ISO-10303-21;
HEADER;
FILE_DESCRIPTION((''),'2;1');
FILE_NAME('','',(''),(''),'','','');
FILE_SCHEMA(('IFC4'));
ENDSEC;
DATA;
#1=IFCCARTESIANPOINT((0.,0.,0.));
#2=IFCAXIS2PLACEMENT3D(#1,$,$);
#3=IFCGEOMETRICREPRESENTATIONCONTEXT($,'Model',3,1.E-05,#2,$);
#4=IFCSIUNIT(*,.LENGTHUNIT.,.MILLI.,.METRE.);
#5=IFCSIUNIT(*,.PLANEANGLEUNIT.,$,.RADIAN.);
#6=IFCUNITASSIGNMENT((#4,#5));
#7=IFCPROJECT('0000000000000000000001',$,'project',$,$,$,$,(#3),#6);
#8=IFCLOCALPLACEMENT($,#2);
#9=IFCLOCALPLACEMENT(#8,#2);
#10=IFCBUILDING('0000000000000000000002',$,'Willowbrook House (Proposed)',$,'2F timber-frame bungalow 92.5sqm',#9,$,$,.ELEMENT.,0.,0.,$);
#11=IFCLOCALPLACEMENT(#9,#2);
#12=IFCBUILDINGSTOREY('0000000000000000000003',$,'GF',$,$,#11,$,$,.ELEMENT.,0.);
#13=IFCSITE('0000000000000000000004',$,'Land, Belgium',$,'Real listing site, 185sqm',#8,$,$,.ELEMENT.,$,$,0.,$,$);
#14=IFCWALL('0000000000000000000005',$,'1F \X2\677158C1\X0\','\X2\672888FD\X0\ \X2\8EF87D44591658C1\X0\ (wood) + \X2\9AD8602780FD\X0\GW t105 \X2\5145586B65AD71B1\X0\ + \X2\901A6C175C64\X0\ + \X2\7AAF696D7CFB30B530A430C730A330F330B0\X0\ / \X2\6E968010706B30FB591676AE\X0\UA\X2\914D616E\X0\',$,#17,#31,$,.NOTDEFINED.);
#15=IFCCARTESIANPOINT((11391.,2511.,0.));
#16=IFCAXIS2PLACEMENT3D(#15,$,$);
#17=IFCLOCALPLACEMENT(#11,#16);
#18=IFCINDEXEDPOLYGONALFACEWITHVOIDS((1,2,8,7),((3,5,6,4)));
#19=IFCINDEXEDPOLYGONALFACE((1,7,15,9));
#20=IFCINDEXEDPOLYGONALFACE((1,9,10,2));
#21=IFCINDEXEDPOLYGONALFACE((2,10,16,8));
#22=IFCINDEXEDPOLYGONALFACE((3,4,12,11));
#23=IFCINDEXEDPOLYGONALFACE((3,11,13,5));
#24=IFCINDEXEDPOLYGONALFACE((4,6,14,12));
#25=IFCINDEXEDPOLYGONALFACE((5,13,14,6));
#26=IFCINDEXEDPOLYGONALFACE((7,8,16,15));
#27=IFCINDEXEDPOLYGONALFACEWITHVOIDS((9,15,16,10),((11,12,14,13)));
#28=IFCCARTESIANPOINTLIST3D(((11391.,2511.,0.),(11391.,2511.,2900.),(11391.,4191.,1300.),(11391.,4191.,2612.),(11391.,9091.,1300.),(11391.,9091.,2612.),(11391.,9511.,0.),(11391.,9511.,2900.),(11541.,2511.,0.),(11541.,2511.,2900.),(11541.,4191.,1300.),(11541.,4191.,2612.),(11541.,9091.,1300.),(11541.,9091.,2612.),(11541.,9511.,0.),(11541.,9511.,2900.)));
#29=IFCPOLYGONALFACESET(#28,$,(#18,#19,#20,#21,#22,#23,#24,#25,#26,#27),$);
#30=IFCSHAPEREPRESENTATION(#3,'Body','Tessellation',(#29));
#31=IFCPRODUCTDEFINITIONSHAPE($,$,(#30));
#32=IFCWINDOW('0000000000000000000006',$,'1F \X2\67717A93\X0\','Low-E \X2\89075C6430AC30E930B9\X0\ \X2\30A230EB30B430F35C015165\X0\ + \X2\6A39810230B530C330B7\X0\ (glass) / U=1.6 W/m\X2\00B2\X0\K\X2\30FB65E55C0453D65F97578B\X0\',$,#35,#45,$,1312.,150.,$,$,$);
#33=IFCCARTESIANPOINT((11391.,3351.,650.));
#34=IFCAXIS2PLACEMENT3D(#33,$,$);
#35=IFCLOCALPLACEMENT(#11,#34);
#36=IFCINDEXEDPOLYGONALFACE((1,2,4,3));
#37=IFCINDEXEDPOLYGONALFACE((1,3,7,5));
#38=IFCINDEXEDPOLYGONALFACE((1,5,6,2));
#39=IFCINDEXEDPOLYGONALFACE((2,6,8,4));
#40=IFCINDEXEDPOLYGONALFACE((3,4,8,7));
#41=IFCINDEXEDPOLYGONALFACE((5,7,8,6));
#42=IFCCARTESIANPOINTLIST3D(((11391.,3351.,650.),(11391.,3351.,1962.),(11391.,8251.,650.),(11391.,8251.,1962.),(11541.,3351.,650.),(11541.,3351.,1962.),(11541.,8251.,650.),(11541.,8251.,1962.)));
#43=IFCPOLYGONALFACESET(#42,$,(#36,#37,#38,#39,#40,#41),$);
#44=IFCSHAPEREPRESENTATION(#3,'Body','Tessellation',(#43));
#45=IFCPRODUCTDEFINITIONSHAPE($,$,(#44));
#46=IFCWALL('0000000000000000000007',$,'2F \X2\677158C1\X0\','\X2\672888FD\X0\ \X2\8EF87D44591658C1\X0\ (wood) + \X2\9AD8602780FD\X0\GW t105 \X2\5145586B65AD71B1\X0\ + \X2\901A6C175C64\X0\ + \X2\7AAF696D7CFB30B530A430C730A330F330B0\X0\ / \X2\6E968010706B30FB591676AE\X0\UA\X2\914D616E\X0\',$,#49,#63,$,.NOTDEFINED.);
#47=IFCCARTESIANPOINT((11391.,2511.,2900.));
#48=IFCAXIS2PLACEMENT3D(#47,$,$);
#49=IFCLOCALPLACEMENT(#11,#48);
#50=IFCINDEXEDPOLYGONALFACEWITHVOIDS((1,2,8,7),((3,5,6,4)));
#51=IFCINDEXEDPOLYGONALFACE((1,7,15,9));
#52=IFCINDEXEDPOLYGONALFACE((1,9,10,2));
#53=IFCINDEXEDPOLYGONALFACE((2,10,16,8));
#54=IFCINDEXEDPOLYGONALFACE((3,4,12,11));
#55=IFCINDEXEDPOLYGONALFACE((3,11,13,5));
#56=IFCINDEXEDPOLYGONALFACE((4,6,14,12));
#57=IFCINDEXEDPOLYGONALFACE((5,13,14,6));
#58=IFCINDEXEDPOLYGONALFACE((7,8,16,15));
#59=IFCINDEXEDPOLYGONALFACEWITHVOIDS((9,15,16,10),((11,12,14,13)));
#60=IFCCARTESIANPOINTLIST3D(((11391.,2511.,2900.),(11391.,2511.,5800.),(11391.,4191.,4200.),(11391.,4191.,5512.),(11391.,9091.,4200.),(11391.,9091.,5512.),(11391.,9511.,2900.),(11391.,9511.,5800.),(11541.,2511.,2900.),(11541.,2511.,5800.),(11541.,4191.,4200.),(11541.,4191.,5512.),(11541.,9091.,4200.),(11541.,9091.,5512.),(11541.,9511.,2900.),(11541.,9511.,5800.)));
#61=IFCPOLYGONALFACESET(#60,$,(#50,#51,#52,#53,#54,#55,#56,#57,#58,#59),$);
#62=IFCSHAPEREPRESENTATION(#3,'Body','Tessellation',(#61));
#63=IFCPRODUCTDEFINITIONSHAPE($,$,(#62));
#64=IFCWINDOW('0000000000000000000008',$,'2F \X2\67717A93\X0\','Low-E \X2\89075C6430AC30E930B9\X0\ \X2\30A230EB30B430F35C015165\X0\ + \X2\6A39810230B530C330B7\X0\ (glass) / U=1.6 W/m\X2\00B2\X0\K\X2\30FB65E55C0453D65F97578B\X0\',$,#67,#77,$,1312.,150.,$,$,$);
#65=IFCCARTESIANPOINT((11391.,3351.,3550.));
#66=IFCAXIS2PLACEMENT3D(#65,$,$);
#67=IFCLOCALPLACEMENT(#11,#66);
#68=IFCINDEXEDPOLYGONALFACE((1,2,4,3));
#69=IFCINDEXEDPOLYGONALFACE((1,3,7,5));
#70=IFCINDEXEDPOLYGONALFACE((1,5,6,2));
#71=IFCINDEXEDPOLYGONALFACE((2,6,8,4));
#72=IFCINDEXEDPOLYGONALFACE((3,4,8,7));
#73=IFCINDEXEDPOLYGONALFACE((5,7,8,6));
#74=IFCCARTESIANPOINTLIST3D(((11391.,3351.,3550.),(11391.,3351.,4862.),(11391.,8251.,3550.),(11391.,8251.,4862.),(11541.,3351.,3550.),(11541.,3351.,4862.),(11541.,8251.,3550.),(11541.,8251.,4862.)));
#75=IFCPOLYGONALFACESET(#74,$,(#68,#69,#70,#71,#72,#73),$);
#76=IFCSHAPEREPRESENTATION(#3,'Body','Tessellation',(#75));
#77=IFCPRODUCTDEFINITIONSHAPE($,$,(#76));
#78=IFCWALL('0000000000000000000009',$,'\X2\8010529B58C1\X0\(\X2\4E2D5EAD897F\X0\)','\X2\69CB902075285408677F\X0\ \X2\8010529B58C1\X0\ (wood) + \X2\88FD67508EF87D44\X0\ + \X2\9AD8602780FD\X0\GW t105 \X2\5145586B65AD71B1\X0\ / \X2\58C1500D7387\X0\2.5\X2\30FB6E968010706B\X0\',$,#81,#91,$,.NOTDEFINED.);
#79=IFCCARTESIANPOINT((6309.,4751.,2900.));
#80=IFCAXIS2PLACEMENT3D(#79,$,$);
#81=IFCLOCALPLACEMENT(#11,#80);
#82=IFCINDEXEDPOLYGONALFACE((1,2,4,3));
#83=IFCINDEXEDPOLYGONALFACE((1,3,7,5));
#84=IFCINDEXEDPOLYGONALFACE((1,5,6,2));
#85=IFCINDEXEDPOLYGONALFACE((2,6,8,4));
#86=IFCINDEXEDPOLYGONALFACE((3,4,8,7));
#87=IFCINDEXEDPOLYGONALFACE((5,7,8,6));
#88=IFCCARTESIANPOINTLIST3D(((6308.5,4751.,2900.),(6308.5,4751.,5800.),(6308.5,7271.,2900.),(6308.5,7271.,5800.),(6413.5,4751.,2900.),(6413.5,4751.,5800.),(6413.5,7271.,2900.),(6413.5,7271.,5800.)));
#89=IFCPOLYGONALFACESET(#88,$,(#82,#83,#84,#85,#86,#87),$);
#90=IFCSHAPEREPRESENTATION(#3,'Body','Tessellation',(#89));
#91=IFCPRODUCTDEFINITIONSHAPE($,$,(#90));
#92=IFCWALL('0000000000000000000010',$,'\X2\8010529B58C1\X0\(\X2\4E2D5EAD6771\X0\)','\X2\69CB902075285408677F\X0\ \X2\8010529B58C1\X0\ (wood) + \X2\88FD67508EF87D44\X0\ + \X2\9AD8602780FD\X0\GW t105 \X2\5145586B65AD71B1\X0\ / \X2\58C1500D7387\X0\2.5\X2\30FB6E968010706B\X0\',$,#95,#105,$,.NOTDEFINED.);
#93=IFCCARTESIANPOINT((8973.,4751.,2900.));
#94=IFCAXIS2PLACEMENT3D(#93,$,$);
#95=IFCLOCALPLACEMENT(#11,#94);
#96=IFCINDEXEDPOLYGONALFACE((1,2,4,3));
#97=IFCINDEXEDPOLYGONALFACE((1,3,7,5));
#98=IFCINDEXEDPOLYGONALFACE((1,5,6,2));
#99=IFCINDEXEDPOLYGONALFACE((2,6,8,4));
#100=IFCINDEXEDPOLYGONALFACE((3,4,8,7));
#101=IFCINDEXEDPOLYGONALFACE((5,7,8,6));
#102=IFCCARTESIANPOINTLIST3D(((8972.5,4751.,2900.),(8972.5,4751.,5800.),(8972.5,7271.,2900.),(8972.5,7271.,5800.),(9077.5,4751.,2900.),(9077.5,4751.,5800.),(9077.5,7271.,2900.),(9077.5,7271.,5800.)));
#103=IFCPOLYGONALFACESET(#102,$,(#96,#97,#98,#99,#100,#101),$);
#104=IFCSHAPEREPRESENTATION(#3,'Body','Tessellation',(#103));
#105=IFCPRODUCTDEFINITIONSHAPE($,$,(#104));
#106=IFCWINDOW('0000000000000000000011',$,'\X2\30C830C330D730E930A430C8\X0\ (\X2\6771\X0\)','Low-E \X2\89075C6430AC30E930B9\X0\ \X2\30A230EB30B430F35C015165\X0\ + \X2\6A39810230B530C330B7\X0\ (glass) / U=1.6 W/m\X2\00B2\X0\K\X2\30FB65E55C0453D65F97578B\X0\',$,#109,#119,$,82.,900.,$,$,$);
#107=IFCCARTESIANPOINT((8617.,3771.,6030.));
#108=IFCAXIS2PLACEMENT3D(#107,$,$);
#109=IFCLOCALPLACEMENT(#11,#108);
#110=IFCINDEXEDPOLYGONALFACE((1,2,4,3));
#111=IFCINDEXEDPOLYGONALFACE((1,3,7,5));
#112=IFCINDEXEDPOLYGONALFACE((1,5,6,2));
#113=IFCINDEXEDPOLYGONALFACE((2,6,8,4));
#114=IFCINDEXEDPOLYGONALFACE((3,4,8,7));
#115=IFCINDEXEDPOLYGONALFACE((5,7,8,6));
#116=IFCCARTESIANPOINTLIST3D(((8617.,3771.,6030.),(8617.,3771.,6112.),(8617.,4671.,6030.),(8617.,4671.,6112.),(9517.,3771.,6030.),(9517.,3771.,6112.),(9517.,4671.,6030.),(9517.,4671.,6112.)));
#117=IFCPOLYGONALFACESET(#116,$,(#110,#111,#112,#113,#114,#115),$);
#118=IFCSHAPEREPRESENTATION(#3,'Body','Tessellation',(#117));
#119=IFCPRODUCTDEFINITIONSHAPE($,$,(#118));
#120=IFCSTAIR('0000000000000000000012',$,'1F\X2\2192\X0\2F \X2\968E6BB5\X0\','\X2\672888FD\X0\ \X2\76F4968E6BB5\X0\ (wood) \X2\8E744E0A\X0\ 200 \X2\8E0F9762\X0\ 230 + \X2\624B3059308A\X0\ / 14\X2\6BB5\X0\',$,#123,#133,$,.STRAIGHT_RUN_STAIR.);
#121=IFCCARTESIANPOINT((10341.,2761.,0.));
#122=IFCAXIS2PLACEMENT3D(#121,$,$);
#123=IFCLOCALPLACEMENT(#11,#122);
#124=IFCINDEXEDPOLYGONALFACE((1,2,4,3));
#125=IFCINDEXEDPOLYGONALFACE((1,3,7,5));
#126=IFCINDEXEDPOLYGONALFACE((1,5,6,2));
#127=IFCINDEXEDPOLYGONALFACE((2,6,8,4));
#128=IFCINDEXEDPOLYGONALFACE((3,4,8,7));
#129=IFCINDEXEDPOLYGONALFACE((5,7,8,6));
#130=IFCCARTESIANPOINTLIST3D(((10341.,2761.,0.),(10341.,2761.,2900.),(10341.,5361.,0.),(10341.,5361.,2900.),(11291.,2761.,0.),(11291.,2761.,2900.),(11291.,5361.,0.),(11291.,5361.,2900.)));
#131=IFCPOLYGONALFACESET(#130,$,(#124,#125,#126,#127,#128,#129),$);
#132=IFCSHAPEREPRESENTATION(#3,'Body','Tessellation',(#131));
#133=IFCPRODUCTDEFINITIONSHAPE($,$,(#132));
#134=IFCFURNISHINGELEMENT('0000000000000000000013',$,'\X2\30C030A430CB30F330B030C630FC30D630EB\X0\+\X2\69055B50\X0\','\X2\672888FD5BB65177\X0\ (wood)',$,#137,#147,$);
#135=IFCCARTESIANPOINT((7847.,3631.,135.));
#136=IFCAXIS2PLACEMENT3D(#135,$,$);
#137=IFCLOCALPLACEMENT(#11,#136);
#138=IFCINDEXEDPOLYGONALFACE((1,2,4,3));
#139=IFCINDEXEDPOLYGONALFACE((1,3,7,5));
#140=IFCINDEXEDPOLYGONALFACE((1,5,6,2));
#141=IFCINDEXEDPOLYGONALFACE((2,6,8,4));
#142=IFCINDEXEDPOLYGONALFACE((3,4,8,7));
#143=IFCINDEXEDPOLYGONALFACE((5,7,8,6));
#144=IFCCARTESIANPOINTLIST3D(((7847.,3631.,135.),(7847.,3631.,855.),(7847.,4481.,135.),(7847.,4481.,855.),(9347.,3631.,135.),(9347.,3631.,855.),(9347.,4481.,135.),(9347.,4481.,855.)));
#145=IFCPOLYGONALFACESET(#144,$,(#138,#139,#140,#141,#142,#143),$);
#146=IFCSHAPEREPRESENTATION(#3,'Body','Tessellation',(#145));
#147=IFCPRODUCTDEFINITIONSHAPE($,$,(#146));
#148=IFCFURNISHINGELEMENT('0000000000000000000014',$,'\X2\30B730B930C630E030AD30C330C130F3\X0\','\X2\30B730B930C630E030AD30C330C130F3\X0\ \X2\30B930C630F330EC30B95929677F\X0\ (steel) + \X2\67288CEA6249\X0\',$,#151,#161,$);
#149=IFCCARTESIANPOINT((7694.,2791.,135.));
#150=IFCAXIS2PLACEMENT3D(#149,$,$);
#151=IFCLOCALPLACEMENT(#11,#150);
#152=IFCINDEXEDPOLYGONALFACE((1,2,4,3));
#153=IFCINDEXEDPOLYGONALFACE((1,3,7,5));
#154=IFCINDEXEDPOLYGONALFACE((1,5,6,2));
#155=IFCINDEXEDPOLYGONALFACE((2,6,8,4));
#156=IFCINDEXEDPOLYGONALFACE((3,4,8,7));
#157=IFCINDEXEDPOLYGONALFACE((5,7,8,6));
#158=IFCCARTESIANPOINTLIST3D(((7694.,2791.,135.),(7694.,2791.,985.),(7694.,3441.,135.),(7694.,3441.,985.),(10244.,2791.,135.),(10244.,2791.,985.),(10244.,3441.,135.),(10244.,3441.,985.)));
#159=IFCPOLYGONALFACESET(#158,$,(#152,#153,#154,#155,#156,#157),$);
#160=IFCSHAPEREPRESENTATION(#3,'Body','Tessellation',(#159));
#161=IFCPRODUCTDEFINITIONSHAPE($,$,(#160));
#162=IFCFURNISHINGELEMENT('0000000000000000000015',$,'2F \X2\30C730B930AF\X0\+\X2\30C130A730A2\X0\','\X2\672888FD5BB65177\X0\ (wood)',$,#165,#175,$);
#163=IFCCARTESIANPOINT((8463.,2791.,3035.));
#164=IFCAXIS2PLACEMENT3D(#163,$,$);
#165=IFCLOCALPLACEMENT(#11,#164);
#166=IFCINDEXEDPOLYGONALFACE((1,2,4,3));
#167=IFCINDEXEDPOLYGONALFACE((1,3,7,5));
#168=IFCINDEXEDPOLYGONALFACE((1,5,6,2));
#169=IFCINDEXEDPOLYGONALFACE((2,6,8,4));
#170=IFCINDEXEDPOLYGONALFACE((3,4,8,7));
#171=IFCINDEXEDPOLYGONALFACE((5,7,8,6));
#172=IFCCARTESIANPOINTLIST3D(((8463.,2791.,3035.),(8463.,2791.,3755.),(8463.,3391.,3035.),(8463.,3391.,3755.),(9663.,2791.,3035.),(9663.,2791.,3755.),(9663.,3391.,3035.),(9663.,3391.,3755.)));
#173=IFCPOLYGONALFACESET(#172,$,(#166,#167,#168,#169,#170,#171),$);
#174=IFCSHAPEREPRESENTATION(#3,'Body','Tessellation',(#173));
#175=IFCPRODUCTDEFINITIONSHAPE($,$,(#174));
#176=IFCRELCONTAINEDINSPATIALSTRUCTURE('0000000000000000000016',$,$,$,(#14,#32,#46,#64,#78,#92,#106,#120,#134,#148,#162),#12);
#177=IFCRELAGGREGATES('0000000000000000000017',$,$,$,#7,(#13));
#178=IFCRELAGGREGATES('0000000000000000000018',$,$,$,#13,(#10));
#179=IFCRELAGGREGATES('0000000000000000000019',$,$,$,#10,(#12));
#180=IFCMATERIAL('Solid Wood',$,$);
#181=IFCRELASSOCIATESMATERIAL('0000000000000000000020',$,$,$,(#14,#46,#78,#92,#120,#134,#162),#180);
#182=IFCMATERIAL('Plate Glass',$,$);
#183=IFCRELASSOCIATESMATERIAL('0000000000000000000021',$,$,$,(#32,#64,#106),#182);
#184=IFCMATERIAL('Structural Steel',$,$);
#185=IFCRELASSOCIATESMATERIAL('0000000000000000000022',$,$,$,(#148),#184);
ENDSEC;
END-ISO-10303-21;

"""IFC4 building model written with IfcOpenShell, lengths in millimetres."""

from ifc_helpers import new_model, si_unit, frame, frame_2d, origin, place, context, project, spatial, rectangle, extrude, material, element, fill, save


model = new_model("IFC4")

# Units and contexts
model_context = context("Model", 3, precision=1e-05, world=origin())
ifc_project = project(units=[si_unit("LENGTHUNIT", "METRE", prefix="MILLI"), si_unit("PLANEANGLEUNIT", "RADIAN")], contexts=[model_context])

# Site, building, storey
site_placement = place(None, origin())
site = spatial("IfcSite", under=ifc_project, at=site_placement, Name="Land, Belgium", ObjectType="Real listing site, 185sqm", CompositionType="ELEMENT", RefElevation=0.0)
building_placement = place(site_placement, origin())
building = spatial("IfcBuilding", under=site, at=building_placement, Name="Willowbrook House (Proposed)", ObjectType="2F timber-frame bungalow 92.5sqm", CompositionType="ELEMENT", ElevationOfRefHeight=0.0, ElevationOfTerrain=0.0)
storey_placement = place(building_placement, origin())
storey = spatial("IfcBuildingStorey", under=building, at=storey_placement, Name="GF", CompositionType="ELEMENT", Elevation=0.0)

# Shared definitions
ifc_material_1 = material(Name="Solid Wood")

# Wall, opening, window
wall_1_placement = place(storey_placement, frame((11391.0, 2511.0, 0.0)))
wall_1 = element("IfcWall", 1, at=wall_1_placement, inside=storey, material=ifc_material_1, Name="1F 東壁", Description="木製 軸組外壁 (wood) + 高性能GW t105 充填断熱 + 通気層 + 窯業系サイディング / 準耐火・外皮UA配慮", PredefinedType="NOTDEFINED", context=model_context, shape_type="SweptSolid", body=[
    extrude(rectangle(XDim=150.0, YDim=7000.0, at=frame_2d((75.0, 3500.0))), frame((11391.0, 2511.0, 0.0)), (0.0, 0.0, 1.0), 2900.0),
])
opening_1_placement = place(storey_placement, frame((11391.0, 3351.0, 650.0)))
opening_1 = element("IfcOpeningElement", 2, at=opening_1_placement, cuts=wall_1, PredefinedType="NOTDEFINED", context=model_context, shape_type="SweptSolid", body=[
    extrude(rectangle(XDim=150.0, YDim=4900.0, at=frame_2d((75.0, 2450.0))), frame((11391.0, 3351.0, 650.0)), (0.0, 0.0, 1.0), 1312.0),
])
ifc_material_2 = material(Name="Plate Glass")
window_1_placement = place(storey_placement, frame((11391.0, 3351.0, 650.0)))
window_1 = element("IfcWindow", 3, at=window_1_placement, inside=storey, material=ifc_material_2, Name="1F 東窓", Description="Low-E 複層ガラス アルゴン封入 + 樹脂サッシ (glass) / U=1.6 W/m²K・日射取得型", OverallHeight=1312.0, OverallWidth=150.0, context=model_context, shape_type="SweptSolid", body=[
    extrude(rectangle(XDim=150.0, YDim=4900.0, at=frame_2d((75.0, 2450.0))), frame((11391.0, 3351.0, 650.0)), (0.0, 0.0, 1.0), 1312.0),
])
fill(opening_1, window_1)

# Wall, opening, window
wall_2_placement = place(storey_placement, frame((11391.0, 2511.0, 2900.0)))
wall_2 = element("IfcWall", 4, at=wall_2_placement, inside=storey, material=ifc_material_1, Name="2F 東壁", Description="木製 軸組外壁 (wood) + 高性能GW t105 充填断熱 + 通気層 + 窯業系サイディング / 準耐火・外皮UA配慮", PredefinedType="NOTDEFINED", context=model_context, shape_type="SweptSolid", body=[
    extrude(rectangle(XDim=150.0, YDim=7000.0, at=frame_2d((75.0, 3500.0))), frame((11391.0, 2511.0, 2900.0)), (0.0, 0.0, 1.0), 2900.0),
])
opening_2_placement = place(storey_placement, frame((11391.0, 3351.0, 3550.0)))
opening_2 = element("IfcOpeningElement", 5, at=opening_2_placement, cuts=wall_2, PredefinedType="NOTDEFINED", context=model_context, shape_type="SweptSolid", body=[
    extrude(rectangle(XDim=150.0, YDim=4900.0, at=frame_2d((75.0, 2450.0))), frame((11391.0, 3351.0, 3550.0)), (0.0, 0.0, 1.0), 1312.0),
])
window_2_placement = place(storey_placement, frame((11391.0, 3351.0, 3550.0)))
window_2 = element("IfcWindow", 6, at=window_2_placement, inside=storey, material=ifc_material_2, Name="2F 東窓", Description="Low-E 複層ガラス アルゴン封入 + 樹脂サッシ (glass) / U=1.6 W/m²K・日射取得型", OverallHeight=1312.0, OverallWidth=150.0, context=model_context, shape_type="SweptSolid", body=[
    extrude(rectangle(XDim=150.0, YDim=4900.0, at=frame_2d((75.0, 2450.0))), frame((11391.0, 3351.0, 3550.0)), (0.0, 0.0, 1.0), 1312.0),
])
fill(opening_2, window_2)

# Walls
wall_3_placement = place(storey_placement, frame((6309.0, 4751.0, 2900.0)))
element("IfcWall", 7, at=wall_3_placement, inside=storey, material=ifc_material_1, Name="耐力壁(中庭西)", Description="構造用合板 耐力壁 (wood) + 製材軸組 + 高性能GW t105 充填断熱 / 壁倍率2.5・準耐火", PredefinedType="NOTDEFINED", context=model_context, shape_type="SweptSolid", body=[
    extrude(rectangle(XDim=105.0, YDim=2520.0, at=frame_2d((52.0, 1260.0))), frame((6309.0, 4751.0, 2900.0)), (0.0, 0.0, 1.0), 2900.0),
])
wall_4_placement = place(storey_placement, frame((8973.0, 4751.0, 2900.0)))
element("IfcWall", 8, at=wall_4_placement, inside=storey, material=ifc_material_1, Name="耐力壁(中庭東)", Description="構造用合板 耐力壁 (wood) + 製材軸組 + 高性能GW t105 充填断熱 / 壁倍率2.5・準耐火", PredefinedType="NOTDEFINED", context=model_context, shape_type="SweptSolid", body=[
    extrude(rectangle(XDim=105.0, YDim=2520.0, at=frame_2d((52.0, 1260.0))), frame((8973.0, 4751.0, 2900.0)), (0.0, 0.0, 1.0), 2900.0),
])

# Window
window_3_placement = place(storey_placement, frame((8617.0, 3771.0, 6030.0)))
element("IfcWindow", 9, at=window_3_placement, inside=storey, material=ifc_material_2, Name="トップライト (東)", Description="Low-E 複層ガラス アルゴン封入 + 樹脂サッシ (glass) / U=1.6 W/m²K・日射取得型", OverallHeight=82.0, OverallWidth=900.0, context=model_context, shape_type="SweptSolid", body=[
    extrude(rectangle(XDim=900.0, YDim=900.0, at=frame_2d((450.0, 450.0))), frame((8617.0, 3771.0, 6030.0)), (0.0, 0.0, 1.0), 82.0),
])

# Stair
stair_placement = place(storey_placement, frame((10341.0, 2761.0, 0.0)))
element("IfcStair", 10, at=stair_placement, inside=storey, material=ifc_material_1, Name="1F→2F 階段", Description="木製 直階段 (wood) 蹴上 200 踏面 230 + 手すり / 14段", PredefinedType="STRAIGHT_RUN_STAIR", context=model_context, shape_type="SweptSolid", body=[
    extrude(rectangle(XDim=950.0, YDim=2600.0, at=frame_2d((475.0, 1300.0))), frame((10341.0, 2761.0, 0.0)), (0.0, 0.0, 1.0), 2900.0),
])

# Furnishing elements
furnishing_1_placement = place(storey_placement, frame((7847.0, 3631.0, 135.0)))
element("IfcFurnishingElement", 11, at=furnishing_1_placement, inside=storey, material=ifc_material_1, Name="ダイニングテーブル+椅子", Description="木製家具 (wood)", context=model_context, shape_type="SweptSolid", body=[
    extrude(rectangle(XDim=1500.0, YDim=850.0, at=frame_2d((750.0, 425.0))), frame((7847.0, 3631.0, 135.0)), (0.0, 0.0, 1.0), 720.0),
])
ifc_material_3 = material(Name="Structural Steel")
furnishing_2_placement = place(storey_placement, frame((7694.0, 2791.0, 135.0)))
element("IfcFurnishingElement", 12, at=furnishing_2_placement, inside=storey, material=ifc_material_3, Name="システムキッチン", Description="システムキッチン ステンレス天板 (steel) + 木質扉", context=model_context, shape_type="SweptSolid", body=[
    extrude(rectangle(XDim=2550.0, YDim=650.0, at=frame_2d((1275.0, 325.0))), frame((7694.0, 2791.0, 135.0)), (0.0, 0.0, 1.0), 850.0),
])
furnishing_3_placement = place(storey_placement, frame((8463.0, 2791.0, 3035.0)))
element("IfcFurnishingElement", 13, at=furnishing_3_placement, inside=storey, material=ifc_material_1, Name="2F デスク+チェア", Description="木製家具 (wood)", context=model_context, shape_type="SweptSolid", body=[
    extrude(rectangle(XDim=1200.0, YDim=600.0, at=frame_2d((600.0, 300.0))), frame((8463.0, 2791.0, 3035.0)), (0.0, 0.0, 1.0), 720.0),
])

save(model, "model.ifc")
